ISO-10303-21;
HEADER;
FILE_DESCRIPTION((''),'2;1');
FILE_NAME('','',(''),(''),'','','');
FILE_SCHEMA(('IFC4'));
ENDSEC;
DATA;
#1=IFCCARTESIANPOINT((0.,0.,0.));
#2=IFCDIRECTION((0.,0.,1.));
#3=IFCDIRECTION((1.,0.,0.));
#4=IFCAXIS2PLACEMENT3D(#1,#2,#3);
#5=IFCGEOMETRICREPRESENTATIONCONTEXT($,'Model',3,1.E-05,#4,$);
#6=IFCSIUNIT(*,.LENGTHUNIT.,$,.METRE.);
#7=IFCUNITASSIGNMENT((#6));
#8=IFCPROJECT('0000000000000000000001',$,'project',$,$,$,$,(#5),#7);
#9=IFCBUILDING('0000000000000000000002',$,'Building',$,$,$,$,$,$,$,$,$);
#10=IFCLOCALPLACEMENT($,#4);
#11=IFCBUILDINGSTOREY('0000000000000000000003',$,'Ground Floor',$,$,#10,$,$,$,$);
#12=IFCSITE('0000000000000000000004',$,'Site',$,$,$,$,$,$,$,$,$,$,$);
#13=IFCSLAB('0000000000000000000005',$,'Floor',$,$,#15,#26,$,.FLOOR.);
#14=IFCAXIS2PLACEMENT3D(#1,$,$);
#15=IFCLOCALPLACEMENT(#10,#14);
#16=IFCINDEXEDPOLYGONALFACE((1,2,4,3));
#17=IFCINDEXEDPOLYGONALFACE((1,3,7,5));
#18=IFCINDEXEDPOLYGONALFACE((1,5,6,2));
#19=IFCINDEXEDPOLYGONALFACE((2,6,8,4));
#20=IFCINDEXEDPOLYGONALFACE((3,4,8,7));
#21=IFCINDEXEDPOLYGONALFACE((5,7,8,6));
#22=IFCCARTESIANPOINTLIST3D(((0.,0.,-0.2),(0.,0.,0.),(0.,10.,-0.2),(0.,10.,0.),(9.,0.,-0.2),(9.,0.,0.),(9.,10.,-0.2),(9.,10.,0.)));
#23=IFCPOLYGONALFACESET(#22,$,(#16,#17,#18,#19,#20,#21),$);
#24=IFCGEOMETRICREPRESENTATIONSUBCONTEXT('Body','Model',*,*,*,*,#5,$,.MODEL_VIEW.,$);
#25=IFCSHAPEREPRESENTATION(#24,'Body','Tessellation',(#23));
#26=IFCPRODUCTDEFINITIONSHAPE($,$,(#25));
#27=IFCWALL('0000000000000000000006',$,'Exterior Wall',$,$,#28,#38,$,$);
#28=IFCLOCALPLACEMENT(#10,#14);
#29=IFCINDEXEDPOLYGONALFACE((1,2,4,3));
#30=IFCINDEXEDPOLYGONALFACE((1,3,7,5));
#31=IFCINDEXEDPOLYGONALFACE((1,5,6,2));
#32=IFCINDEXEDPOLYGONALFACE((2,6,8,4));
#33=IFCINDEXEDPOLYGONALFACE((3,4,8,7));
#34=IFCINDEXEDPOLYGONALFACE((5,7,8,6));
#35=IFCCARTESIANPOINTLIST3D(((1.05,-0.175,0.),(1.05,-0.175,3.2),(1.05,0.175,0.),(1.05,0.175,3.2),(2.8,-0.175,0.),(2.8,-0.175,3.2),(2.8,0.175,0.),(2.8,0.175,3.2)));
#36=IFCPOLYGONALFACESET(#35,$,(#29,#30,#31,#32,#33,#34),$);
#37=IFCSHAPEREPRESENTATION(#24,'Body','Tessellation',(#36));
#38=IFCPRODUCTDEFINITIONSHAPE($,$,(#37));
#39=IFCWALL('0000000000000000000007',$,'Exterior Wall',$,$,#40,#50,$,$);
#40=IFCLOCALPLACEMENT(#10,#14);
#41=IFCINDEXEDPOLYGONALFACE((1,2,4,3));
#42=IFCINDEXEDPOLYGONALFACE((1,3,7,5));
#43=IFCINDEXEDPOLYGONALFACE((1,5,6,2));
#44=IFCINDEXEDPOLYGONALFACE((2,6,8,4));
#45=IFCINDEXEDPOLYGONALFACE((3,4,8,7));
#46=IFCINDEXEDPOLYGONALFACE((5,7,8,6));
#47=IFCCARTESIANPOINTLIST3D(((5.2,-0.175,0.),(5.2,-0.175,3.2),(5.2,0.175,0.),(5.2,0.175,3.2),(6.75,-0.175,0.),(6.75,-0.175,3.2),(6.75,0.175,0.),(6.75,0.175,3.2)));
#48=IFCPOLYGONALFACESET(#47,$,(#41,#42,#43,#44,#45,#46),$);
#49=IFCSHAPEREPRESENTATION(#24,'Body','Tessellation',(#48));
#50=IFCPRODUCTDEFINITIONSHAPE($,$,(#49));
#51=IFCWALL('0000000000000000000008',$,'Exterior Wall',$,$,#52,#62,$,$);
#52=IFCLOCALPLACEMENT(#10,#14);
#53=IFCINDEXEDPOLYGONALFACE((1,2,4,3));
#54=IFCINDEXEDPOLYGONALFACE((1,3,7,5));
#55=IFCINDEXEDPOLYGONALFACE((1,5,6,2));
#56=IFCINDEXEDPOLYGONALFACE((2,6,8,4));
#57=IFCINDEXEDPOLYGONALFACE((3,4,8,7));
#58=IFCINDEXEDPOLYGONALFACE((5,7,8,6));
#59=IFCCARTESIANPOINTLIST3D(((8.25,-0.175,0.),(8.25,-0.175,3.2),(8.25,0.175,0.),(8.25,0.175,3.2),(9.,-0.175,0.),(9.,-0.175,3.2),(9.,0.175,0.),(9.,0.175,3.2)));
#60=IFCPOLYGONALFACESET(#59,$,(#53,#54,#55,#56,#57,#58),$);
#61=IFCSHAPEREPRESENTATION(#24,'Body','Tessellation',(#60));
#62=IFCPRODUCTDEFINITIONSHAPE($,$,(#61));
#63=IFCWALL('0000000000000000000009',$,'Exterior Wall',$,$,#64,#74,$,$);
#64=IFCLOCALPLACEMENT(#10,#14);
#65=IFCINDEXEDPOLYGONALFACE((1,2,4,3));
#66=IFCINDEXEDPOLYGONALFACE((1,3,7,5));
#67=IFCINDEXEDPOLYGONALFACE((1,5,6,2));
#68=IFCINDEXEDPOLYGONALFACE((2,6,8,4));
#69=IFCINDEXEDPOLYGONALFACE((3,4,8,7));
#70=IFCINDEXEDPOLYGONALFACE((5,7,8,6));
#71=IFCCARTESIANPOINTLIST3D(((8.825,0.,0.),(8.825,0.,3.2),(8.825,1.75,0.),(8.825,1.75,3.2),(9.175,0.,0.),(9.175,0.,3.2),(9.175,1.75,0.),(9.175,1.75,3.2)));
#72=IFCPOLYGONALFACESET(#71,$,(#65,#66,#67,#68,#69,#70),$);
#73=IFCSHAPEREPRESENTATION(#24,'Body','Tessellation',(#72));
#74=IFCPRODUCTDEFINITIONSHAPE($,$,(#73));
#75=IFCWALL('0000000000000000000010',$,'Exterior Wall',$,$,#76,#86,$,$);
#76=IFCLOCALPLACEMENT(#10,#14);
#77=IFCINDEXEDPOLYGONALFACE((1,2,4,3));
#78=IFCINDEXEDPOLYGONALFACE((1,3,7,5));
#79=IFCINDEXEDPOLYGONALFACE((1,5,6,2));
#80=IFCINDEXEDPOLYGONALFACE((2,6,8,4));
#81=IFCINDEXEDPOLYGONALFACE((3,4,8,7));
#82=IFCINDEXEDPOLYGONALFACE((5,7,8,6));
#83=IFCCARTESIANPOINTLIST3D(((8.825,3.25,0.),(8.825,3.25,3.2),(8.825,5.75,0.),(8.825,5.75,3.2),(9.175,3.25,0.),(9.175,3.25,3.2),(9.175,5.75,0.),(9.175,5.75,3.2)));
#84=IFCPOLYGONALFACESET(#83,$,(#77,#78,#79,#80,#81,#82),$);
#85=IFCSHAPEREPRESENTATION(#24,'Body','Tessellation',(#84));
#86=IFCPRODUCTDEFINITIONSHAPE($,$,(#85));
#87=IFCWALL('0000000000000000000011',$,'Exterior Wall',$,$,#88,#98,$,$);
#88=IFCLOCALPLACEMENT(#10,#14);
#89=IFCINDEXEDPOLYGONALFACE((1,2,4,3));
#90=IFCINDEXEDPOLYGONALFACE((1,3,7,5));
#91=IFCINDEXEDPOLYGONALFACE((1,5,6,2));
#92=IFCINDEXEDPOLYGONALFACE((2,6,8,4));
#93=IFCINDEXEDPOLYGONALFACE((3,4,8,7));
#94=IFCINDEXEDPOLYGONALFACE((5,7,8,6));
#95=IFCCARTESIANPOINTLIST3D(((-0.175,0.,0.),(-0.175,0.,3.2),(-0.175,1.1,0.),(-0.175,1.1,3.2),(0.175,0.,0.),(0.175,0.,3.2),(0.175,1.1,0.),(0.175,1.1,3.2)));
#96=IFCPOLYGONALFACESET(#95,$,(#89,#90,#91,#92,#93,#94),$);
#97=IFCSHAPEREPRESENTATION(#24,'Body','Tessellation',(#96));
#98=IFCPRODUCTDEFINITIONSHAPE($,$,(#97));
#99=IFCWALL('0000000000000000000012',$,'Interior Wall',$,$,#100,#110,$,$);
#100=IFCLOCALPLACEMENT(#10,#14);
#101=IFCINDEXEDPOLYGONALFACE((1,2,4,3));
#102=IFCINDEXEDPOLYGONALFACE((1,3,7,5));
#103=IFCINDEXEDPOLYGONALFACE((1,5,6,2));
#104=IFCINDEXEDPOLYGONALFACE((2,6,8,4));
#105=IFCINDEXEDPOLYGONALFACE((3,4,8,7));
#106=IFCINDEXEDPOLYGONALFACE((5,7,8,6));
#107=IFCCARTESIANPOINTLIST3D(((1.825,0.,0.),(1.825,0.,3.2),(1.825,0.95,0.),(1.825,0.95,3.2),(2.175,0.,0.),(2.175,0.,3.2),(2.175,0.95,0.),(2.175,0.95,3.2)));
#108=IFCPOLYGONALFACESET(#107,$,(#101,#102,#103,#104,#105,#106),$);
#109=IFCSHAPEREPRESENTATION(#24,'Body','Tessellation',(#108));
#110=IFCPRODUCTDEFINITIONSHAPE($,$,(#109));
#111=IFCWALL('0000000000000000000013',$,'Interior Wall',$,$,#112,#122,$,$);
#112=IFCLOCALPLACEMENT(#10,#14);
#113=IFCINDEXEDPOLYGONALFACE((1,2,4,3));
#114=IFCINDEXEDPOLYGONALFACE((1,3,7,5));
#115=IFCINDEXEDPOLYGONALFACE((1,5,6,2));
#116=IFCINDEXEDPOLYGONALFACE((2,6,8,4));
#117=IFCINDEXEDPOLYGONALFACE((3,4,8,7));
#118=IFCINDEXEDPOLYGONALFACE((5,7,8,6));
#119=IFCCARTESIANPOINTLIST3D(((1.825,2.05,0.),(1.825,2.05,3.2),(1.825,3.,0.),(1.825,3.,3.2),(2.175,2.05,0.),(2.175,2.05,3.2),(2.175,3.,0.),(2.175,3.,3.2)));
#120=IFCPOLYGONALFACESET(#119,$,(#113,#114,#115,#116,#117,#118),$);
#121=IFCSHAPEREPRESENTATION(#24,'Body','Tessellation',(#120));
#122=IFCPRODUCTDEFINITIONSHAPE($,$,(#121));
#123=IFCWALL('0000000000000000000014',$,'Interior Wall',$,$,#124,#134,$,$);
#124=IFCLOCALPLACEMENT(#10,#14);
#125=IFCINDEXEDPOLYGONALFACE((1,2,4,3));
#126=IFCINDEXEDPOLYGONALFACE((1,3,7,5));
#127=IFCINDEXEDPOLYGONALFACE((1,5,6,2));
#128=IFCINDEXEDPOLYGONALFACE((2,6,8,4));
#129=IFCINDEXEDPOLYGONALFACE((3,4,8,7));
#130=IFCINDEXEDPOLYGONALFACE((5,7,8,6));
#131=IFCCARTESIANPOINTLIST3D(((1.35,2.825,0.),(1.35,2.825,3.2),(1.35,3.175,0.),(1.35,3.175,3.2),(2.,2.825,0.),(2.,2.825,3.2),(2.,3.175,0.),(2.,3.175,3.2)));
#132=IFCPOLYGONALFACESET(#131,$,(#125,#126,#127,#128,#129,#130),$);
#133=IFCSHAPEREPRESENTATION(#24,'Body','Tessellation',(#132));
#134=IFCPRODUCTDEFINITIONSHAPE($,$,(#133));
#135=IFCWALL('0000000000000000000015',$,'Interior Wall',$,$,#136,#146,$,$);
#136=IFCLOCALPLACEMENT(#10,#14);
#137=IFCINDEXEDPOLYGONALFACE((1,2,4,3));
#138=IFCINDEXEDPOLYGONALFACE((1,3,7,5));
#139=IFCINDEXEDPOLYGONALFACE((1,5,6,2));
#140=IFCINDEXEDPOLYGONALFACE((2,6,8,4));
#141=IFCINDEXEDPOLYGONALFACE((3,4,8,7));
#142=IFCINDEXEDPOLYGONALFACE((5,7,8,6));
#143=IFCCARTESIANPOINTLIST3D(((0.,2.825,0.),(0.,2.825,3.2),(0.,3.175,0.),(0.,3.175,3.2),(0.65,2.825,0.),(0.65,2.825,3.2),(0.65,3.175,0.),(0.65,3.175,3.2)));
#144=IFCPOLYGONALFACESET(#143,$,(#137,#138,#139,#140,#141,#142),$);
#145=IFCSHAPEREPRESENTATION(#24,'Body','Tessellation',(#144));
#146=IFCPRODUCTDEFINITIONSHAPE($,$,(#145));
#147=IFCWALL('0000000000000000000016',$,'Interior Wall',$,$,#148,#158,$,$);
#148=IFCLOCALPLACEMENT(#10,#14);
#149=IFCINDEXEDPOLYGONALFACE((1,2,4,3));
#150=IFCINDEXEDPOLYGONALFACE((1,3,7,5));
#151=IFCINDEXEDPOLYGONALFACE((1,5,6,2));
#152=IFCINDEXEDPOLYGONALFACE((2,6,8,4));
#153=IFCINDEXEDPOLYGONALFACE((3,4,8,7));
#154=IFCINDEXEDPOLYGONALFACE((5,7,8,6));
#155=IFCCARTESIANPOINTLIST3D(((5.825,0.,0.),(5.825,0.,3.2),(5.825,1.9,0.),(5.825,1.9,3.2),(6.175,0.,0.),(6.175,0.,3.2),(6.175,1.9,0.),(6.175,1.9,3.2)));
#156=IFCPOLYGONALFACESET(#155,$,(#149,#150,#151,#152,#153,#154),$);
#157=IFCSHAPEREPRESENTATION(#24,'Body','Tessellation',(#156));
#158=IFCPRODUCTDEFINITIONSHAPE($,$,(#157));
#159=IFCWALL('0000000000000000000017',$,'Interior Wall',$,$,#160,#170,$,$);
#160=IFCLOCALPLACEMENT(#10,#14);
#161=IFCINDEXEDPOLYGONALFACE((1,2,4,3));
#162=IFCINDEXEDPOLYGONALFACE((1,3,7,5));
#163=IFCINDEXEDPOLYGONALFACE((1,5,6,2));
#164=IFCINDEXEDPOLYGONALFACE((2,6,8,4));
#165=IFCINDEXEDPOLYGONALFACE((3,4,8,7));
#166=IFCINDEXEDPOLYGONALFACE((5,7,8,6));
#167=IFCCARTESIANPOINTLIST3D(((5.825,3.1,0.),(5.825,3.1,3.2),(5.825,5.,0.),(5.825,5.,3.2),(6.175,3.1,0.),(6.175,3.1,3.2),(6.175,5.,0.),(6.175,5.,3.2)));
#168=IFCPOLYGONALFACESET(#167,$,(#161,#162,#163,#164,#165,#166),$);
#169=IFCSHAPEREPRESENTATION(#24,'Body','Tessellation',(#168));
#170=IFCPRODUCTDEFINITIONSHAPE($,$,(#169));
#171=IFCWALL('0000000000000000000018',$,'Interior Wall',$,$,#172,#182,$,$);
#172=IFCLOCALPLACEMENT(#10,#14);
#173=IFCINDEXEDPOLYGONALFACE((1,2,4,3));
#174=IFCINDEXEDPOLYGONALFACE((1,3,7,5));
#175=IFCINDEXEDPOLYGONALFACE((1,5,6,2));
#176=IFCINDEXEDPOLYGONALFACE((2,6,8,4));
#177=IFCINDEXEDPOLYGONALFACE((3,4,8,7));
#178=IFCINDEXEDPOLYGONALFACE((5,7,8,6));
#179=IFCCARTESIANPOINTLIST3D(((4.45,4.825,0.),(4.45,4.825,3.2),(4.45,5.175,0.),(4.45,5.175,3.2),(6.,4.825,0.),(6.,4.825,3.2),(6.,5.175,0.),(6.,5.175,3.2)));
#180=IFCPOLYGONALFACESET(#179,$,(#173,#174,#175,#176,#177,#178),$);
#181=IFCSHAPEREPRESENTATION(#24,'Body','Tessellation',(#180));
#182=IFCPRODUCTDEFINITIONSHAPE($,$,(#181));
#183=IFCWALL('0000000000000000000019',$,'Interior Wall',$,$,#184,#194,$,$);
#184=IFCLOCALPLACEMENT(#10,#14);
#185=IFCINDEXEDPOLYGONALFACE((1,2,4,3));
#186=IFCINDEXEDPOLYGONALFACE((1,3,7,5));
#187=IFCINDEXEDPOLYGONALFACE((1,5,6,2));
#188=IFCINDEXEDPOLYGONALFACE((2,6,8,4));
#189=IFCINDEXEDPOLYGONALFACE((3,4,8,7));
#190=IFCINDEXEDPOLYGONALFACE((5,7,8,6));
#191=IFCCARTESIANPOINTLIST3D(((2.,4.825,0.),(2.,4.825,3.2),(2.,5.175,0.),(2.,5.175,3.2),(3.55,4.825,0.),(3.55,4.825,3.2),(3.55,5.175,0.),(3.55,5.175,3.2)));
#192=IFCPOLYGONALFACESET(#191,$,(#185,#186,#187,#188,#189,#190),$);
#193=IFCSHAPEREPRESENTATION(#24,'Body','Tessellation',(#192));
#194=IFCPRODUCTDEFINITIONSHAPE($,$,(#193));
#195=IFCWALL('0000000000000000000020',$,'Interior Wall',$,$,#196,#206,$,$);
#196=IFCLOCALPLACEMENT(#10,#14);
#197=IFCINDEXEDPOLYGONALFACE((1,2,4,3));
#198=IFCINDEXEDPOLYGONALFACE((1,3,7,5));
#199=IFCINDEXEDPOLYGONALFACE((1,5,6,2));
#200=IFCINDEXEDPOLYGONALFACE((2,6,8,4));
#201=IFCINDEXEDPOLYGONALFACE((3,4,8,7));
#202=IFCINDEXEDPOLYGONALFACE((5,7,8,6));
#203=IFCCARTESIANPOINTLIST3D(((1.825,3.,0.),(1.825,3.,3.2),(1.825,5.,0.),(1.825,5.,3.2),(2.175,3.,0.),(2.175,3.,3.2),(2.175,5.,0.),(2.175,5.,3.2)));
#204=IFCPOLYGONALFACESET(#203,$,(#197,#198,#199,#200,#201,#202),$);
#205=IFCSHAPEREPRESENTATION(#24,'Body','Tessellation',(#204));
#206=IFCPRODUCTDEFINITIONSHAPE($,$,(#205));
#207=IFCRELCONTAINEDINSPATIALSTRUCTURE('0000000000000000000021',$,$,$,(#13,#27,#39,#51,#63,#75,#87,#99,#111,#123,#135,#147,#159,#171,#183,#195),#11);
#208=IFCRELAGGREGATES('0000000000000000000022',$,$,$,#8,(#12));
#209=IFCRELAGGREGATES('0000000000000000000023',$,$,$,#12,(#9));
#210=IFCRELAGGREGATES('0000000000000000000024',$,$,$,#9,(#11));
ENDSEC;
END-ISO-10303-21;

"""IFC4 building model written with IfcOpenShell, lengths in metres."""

from ifc_helpers import new_model, si_unit, frame, origin_with_axes, place, context, subcontext, project, spatial, indexed_curve, outline, extrude, element, save


model = new_model("IFC4")

# Units and contexts
model_context = context("Model", 3, precision=1e-05, world=origin_with_axes())
body_context = subcontext(model_context, "Body", "Model", "MODEL_VIEW")
ifc_project = project(units=[si_unit("LENGTHUNIT", "METRE")], contexts=[model_context])

# Site, building, storey
site = spatial("IfcSite", under=ifc_project, Name="Site")
building = spatial("IfcBuilding", under=site, Name="Building")
storey_placement = place(None, origin_with_axes())
storey = spatial("IfcBuildingStorey", under=building, at=storey_placement, Name="Ground Floor")

# Slab
slab_placement = place(storey_placement, frame((0.0, 0.0, -0.2), z_axis=(0.0, 0.0, 1.0), x_axis=(1.0, 0.0, 0.0)))
element("IfcSlab", 1, at=slab_placement, inside=storey, Name="Floor", PredefinedType="FLOOR", context=body_context, shape_type="SweptSolid", body=[
    extrude(outline(indexed_curve([(0.0, 0.0), (9.0, 0.0), (9.0, 10.0), (0.0, 10.0)])), None, (0.0, 0.0, 1.0), 0.2),
])

# Walls
wall_1_placement = place(storey_placement, frame((1.05, 0.0, 0.0), z_axis=(0.0, 0.0, 1.0), x_axis=(1.0, 0.0, 0.0)))
element("IfcWall", 2, at=wall_1_placement, inside=storey, Name="Exterior Wall", context=body_context, shape_type="SweptSolid", body=[
    extrude(outline(indexed_curve([(0.0, 0.0), (0.0, 0.35), (1.75, 0.35), (1.75, 0.0), (0.0, 0.0)], self_intersect=False)), frame((0.0, -0.175, 0.0), z_axis=(0.0, 0.0, 1.0), x_axis=(1.0, 0.0, 0.0)), (0.0, 0.0, 1.0), 3.2),
])
wall_2_placement = place(storey_placement, frame((5.2, 0.0, 0.0), z_axis=(0.0, 0.0, 1.0), x_axis=(1.0, 0.0, 0.0)))
element("IfcWall", 3, at=wall_2_placement, inside=storey, Name="Exterior Wall", context=body_context, shape_type="SweptSolid", body=[
    extrude(outline(indexed_curve([(0.0, 0.0), (0.0, 0.35), (1.55, 0.35), (1.55, 0.0), (0.0, 0.0)], self_intersect=False)), frame((0.0, -0.175, 0.0), z_axis=(0.0, 0.0, 1.0), x_axis=(1.0, 0.0, 0.0)), (0.0, 0.0, 1.0), 3.2),
])
wall_3_placement = place(storey_placement, frame((8.25, 0.0, 0.0), z_axis=(0.0, 0.0, 1.0), x_axis=(1.0, 0.0, 0.0)))
element("IfcWall", 4, at=wall_3_placement, inside=storey, Name="Exterior Wall", context=body_context, shape_type="SweptSolid", body=[
    extrude(outline(indexed_curve([(0.0, 0.0), (0.0, 0.35), (0.75, 0.35), (0.75, 0.0), (0.0, 0.0)], self_intersect=False)), frame((0.0, -0.175, 0.0), z_axis=(0.0, 0.0, 1.0), x_axis=(1.0, 0.0, 0.0)), (0.0, 0.0, 1.0), 3.2),
])
wall_4_placement = place(storey_placement, frame((9.0, 0.0, 0.0), z_axis=(0.0, 0.0, 1.0), x_axis=(0.0, 1.0, 0.0)))
element("IfcWall", 5, at=wall_4_placement, inside=storey, Name="Exterior Wall", context=body_context, shape_type="SweptSolid", body=[
    extrude(outline(indexed_curve([(0.0, 0.0), (0.0, 0.35), (1.75, 0.35), (1.75, 0.0), (0.0, 0.0)], self_intersect=False)), frame((0.0, -0.175, 0.0), z_axis=(0.0, 0.0, 1.0), x_axis=(1.0, 0.0, 0.0)), (0.0, 0.0, 1.0), 3.2),
])
wall_5_placement = place(storey_placement, frame((9.0, 3.25, 0.0), z_axis=(0.0, 0.0, 1.0), x_axis=(0.0, 1.0, 0.0)))
element("IfcWall", 6, at=wall_5_placement, inside=storey, Name="Exterior Wall", context=body_context, shape_type="SweptSolid", body=[
    extrude(outline(indexed_curve([(0.0, 0.0), (0.0, 0.35), (2.5, 0.35), (2.5, 0.0), (0.0, 0.0)], self_intersect=False)), frame((0.0, -0.175, 0.0), z_axis=(0.0, 0.0, 1.0), x_axis=(1.0, 0.0, 0.0)), (0.0, 0.0, 1.0), 3.2),
])
wall_6_placement = place(storey_placement, frame((0.0, 1.1, 0.0), z_axis=(0.0, 0.0, 1.0), x_axis=(0.0, -1.0, 0.0)))
element("IfcWall", 7, at=wall_6_placement, inside=storey, Name="Exterior Wall", context=body_context, shape_type="SweptSolid", body=[
    extrude(outline(indexed_curve([(0.0, 0.0), (0.0, 0.35), (1.1, 0.35), (1.1, 0.0), (0.0, 0.0)], self_intersect=False)), frame((0.0, -0.175, 0.0), z_axis=(0.0, 0.0, 1.0), x_axis=(1.0, 0.0, 0.0)), (0.0, 0.0, 1.0), 3.2),
])
wall_7_placement = place(storey_placement, frame((2.0, 0.0, 0.0), z_axis=(0.0, 0.0, 1.0), x_axis=(0.0, 1.0, 0.0)))
element("IfcWall", 8, at=wall_7_placement, inside=storey, Name="Interior Wall", context=body_context, shape_type="SweptSolid", body=[
    extrude(outline(indexed_curve([(0.0, 0.0), (0.0, 0.35), (0.95, 0.35), (0.95, 0.0), (0.0, 0.0)], self_intersect=False)), frame((0.0, -0.175, 0.0), z_axis=(0.0, 0.0, 1.0), x_axis=(1.0, 0.0, 0.0)), (0.0, 0.0, 1.0), 3.2),
])
wall_8_placement = place(storey_placement, frame((2.0, 2.05, 0.0), z_axis=(0.0, 0.0, 1.0), x_axis=(0.0, 1.0, 0.0)))
element("IfcWall", 9, at=wall_8_placement, inside=storey, Name="Interior Wall", context=body_context, shape_type="SweptSolid", body=[
    extrude(outline(indexed_curve([(0.0, 0.0), (0.0, 0.35), (0.95, 0.35), (0.95, 0.0), (0.0, 0.0)], self_intersect=False)), frame((0.0, -0.175, 0.0), z_axis=(0.0, 0.0, 1.0), x_axis=(1.0, 0.0, 0.0)), (0.0, 0.0, 1.0), 3.2),
])
for number, where, z_axis, x_axis, name in (
    (10, (2.0, 3.0, 0.0), (0.0, 0.0, 1.0), (-1.0, 0.0, 0.0), "Interior Wall"),
    (11, (0.65, 3.0, 0.0), (0.0, 0.0, 1.0), (-1.0, 0.0, 0.0), "Interior Wall"),
):
    element("IfcWall", number, at=place(storey_placement, frame(where, z_axis=z_axis, x_axis=x_axis)), inside=storey, Name=name, context=body_context, shape_type="SweptSolid", body=[
        extrude(outline(indexed_curve([(0.0, 0.0), (0.0, 0.35), (0.65, 0.35), (0.65, 0.0), (0.0, 0.0)], self_intersect=False)), frame((0.0, -0.175, 0.0), z_axis=(0.0, 0.0, 1.0), x_axis=(1.0, 0.0, 0.0)), (0.0, 0.0, 1.0), 3.2),
    ])
for number, where, z_axis, x_axis, name in (
    (12, (6.0, 0.0, 0.0), (0.0, 0.0, 1.0), (0.0, 1.0, 0.0), "Interior Wall"),
    (13, (6.0, 3.1, 0.0), (0.0, 0.0, 1.0), (0.0, 1.0, 0.0), "Interior Wall"),
):
    element("IfcWall", number, at=place(storey_placement, frame(where, z_axis=z_axis, x_axis=x_axis)), inside=storey, Name=name, context=body_context, shape_type="SweptSolid", body=[
        extrude(outline(indexed_curve([(0.0, 0.0), (0.0, 0.35), (1.9, 0.35), (1.9, 0.0), (0.0, 0.0)], self_intersect=False)), frame((0.0, -0.175, 0.0), z_axis=(0.0, 0.0, 1.0), x_axis=(1.0, 0.0, 0.0)), (0.0, 0.0, 1.0), 3.2),
    ])
for number, where, z_axis, x_axis, name in (
    (14, (6.0, 5.0, 0.0), (0.0, 0.0, 1.0), (-1.0, 0.0, 0.0), "Interior Wall"),
    (15, (3.55, 5.0, 0.0), (0.0, 0.0, 1.0), (-1.0, 0.0, 0.0), "Interior Wall"),
):
    element("IfcWall", number, at=place(storey_placement, frame(where, z_axis=z_axis, x_axis=x_axis)), inside=storey, Name=name, context=body_context, shape_type="SweptSolid", body=[
        extrude(outline(indexed_curve([(0.0, 0.0), (0.0, 0.35), (1.55, 0.35), (1.55, 0.0), (0.0, 0.0)], self_intersect=False)), frame((0.0, -0.175, 0.0), z_axis=(0.0, 0.0, 1.0), x_axis=(1.0, 0.0, 0.0)), (0.0, 0.0, 1.0), 3.2),
    ])
wall_9_placement = place(storey_placement, frame((2.0, 5.0, 0.0), z_axis=(0.0, 0.0, 1.0), x_axis=(0.0, -1.0, 0.0)))
element("IfcWall", 16, at=wall_9_placement, inside=storey, Name="Interior Wall", context=body_context, shape_type="SweptSolid", body=[
    extrude(outline(indexed_curve([(0.0, 0.0), (0.0, 0.35), (2.0, 0.35), (2.0, 0.0), (0.0, 0.0)], self_intersect=False)), frame((0.0, -0.175, 0.0), z_axis=(0.0, 0.0, 1.0), x_axis=(1.0, 0.0, 0.0)), (0.0, 0.0, 1.0), 3.2),
])

save(model, "model.ifc")
